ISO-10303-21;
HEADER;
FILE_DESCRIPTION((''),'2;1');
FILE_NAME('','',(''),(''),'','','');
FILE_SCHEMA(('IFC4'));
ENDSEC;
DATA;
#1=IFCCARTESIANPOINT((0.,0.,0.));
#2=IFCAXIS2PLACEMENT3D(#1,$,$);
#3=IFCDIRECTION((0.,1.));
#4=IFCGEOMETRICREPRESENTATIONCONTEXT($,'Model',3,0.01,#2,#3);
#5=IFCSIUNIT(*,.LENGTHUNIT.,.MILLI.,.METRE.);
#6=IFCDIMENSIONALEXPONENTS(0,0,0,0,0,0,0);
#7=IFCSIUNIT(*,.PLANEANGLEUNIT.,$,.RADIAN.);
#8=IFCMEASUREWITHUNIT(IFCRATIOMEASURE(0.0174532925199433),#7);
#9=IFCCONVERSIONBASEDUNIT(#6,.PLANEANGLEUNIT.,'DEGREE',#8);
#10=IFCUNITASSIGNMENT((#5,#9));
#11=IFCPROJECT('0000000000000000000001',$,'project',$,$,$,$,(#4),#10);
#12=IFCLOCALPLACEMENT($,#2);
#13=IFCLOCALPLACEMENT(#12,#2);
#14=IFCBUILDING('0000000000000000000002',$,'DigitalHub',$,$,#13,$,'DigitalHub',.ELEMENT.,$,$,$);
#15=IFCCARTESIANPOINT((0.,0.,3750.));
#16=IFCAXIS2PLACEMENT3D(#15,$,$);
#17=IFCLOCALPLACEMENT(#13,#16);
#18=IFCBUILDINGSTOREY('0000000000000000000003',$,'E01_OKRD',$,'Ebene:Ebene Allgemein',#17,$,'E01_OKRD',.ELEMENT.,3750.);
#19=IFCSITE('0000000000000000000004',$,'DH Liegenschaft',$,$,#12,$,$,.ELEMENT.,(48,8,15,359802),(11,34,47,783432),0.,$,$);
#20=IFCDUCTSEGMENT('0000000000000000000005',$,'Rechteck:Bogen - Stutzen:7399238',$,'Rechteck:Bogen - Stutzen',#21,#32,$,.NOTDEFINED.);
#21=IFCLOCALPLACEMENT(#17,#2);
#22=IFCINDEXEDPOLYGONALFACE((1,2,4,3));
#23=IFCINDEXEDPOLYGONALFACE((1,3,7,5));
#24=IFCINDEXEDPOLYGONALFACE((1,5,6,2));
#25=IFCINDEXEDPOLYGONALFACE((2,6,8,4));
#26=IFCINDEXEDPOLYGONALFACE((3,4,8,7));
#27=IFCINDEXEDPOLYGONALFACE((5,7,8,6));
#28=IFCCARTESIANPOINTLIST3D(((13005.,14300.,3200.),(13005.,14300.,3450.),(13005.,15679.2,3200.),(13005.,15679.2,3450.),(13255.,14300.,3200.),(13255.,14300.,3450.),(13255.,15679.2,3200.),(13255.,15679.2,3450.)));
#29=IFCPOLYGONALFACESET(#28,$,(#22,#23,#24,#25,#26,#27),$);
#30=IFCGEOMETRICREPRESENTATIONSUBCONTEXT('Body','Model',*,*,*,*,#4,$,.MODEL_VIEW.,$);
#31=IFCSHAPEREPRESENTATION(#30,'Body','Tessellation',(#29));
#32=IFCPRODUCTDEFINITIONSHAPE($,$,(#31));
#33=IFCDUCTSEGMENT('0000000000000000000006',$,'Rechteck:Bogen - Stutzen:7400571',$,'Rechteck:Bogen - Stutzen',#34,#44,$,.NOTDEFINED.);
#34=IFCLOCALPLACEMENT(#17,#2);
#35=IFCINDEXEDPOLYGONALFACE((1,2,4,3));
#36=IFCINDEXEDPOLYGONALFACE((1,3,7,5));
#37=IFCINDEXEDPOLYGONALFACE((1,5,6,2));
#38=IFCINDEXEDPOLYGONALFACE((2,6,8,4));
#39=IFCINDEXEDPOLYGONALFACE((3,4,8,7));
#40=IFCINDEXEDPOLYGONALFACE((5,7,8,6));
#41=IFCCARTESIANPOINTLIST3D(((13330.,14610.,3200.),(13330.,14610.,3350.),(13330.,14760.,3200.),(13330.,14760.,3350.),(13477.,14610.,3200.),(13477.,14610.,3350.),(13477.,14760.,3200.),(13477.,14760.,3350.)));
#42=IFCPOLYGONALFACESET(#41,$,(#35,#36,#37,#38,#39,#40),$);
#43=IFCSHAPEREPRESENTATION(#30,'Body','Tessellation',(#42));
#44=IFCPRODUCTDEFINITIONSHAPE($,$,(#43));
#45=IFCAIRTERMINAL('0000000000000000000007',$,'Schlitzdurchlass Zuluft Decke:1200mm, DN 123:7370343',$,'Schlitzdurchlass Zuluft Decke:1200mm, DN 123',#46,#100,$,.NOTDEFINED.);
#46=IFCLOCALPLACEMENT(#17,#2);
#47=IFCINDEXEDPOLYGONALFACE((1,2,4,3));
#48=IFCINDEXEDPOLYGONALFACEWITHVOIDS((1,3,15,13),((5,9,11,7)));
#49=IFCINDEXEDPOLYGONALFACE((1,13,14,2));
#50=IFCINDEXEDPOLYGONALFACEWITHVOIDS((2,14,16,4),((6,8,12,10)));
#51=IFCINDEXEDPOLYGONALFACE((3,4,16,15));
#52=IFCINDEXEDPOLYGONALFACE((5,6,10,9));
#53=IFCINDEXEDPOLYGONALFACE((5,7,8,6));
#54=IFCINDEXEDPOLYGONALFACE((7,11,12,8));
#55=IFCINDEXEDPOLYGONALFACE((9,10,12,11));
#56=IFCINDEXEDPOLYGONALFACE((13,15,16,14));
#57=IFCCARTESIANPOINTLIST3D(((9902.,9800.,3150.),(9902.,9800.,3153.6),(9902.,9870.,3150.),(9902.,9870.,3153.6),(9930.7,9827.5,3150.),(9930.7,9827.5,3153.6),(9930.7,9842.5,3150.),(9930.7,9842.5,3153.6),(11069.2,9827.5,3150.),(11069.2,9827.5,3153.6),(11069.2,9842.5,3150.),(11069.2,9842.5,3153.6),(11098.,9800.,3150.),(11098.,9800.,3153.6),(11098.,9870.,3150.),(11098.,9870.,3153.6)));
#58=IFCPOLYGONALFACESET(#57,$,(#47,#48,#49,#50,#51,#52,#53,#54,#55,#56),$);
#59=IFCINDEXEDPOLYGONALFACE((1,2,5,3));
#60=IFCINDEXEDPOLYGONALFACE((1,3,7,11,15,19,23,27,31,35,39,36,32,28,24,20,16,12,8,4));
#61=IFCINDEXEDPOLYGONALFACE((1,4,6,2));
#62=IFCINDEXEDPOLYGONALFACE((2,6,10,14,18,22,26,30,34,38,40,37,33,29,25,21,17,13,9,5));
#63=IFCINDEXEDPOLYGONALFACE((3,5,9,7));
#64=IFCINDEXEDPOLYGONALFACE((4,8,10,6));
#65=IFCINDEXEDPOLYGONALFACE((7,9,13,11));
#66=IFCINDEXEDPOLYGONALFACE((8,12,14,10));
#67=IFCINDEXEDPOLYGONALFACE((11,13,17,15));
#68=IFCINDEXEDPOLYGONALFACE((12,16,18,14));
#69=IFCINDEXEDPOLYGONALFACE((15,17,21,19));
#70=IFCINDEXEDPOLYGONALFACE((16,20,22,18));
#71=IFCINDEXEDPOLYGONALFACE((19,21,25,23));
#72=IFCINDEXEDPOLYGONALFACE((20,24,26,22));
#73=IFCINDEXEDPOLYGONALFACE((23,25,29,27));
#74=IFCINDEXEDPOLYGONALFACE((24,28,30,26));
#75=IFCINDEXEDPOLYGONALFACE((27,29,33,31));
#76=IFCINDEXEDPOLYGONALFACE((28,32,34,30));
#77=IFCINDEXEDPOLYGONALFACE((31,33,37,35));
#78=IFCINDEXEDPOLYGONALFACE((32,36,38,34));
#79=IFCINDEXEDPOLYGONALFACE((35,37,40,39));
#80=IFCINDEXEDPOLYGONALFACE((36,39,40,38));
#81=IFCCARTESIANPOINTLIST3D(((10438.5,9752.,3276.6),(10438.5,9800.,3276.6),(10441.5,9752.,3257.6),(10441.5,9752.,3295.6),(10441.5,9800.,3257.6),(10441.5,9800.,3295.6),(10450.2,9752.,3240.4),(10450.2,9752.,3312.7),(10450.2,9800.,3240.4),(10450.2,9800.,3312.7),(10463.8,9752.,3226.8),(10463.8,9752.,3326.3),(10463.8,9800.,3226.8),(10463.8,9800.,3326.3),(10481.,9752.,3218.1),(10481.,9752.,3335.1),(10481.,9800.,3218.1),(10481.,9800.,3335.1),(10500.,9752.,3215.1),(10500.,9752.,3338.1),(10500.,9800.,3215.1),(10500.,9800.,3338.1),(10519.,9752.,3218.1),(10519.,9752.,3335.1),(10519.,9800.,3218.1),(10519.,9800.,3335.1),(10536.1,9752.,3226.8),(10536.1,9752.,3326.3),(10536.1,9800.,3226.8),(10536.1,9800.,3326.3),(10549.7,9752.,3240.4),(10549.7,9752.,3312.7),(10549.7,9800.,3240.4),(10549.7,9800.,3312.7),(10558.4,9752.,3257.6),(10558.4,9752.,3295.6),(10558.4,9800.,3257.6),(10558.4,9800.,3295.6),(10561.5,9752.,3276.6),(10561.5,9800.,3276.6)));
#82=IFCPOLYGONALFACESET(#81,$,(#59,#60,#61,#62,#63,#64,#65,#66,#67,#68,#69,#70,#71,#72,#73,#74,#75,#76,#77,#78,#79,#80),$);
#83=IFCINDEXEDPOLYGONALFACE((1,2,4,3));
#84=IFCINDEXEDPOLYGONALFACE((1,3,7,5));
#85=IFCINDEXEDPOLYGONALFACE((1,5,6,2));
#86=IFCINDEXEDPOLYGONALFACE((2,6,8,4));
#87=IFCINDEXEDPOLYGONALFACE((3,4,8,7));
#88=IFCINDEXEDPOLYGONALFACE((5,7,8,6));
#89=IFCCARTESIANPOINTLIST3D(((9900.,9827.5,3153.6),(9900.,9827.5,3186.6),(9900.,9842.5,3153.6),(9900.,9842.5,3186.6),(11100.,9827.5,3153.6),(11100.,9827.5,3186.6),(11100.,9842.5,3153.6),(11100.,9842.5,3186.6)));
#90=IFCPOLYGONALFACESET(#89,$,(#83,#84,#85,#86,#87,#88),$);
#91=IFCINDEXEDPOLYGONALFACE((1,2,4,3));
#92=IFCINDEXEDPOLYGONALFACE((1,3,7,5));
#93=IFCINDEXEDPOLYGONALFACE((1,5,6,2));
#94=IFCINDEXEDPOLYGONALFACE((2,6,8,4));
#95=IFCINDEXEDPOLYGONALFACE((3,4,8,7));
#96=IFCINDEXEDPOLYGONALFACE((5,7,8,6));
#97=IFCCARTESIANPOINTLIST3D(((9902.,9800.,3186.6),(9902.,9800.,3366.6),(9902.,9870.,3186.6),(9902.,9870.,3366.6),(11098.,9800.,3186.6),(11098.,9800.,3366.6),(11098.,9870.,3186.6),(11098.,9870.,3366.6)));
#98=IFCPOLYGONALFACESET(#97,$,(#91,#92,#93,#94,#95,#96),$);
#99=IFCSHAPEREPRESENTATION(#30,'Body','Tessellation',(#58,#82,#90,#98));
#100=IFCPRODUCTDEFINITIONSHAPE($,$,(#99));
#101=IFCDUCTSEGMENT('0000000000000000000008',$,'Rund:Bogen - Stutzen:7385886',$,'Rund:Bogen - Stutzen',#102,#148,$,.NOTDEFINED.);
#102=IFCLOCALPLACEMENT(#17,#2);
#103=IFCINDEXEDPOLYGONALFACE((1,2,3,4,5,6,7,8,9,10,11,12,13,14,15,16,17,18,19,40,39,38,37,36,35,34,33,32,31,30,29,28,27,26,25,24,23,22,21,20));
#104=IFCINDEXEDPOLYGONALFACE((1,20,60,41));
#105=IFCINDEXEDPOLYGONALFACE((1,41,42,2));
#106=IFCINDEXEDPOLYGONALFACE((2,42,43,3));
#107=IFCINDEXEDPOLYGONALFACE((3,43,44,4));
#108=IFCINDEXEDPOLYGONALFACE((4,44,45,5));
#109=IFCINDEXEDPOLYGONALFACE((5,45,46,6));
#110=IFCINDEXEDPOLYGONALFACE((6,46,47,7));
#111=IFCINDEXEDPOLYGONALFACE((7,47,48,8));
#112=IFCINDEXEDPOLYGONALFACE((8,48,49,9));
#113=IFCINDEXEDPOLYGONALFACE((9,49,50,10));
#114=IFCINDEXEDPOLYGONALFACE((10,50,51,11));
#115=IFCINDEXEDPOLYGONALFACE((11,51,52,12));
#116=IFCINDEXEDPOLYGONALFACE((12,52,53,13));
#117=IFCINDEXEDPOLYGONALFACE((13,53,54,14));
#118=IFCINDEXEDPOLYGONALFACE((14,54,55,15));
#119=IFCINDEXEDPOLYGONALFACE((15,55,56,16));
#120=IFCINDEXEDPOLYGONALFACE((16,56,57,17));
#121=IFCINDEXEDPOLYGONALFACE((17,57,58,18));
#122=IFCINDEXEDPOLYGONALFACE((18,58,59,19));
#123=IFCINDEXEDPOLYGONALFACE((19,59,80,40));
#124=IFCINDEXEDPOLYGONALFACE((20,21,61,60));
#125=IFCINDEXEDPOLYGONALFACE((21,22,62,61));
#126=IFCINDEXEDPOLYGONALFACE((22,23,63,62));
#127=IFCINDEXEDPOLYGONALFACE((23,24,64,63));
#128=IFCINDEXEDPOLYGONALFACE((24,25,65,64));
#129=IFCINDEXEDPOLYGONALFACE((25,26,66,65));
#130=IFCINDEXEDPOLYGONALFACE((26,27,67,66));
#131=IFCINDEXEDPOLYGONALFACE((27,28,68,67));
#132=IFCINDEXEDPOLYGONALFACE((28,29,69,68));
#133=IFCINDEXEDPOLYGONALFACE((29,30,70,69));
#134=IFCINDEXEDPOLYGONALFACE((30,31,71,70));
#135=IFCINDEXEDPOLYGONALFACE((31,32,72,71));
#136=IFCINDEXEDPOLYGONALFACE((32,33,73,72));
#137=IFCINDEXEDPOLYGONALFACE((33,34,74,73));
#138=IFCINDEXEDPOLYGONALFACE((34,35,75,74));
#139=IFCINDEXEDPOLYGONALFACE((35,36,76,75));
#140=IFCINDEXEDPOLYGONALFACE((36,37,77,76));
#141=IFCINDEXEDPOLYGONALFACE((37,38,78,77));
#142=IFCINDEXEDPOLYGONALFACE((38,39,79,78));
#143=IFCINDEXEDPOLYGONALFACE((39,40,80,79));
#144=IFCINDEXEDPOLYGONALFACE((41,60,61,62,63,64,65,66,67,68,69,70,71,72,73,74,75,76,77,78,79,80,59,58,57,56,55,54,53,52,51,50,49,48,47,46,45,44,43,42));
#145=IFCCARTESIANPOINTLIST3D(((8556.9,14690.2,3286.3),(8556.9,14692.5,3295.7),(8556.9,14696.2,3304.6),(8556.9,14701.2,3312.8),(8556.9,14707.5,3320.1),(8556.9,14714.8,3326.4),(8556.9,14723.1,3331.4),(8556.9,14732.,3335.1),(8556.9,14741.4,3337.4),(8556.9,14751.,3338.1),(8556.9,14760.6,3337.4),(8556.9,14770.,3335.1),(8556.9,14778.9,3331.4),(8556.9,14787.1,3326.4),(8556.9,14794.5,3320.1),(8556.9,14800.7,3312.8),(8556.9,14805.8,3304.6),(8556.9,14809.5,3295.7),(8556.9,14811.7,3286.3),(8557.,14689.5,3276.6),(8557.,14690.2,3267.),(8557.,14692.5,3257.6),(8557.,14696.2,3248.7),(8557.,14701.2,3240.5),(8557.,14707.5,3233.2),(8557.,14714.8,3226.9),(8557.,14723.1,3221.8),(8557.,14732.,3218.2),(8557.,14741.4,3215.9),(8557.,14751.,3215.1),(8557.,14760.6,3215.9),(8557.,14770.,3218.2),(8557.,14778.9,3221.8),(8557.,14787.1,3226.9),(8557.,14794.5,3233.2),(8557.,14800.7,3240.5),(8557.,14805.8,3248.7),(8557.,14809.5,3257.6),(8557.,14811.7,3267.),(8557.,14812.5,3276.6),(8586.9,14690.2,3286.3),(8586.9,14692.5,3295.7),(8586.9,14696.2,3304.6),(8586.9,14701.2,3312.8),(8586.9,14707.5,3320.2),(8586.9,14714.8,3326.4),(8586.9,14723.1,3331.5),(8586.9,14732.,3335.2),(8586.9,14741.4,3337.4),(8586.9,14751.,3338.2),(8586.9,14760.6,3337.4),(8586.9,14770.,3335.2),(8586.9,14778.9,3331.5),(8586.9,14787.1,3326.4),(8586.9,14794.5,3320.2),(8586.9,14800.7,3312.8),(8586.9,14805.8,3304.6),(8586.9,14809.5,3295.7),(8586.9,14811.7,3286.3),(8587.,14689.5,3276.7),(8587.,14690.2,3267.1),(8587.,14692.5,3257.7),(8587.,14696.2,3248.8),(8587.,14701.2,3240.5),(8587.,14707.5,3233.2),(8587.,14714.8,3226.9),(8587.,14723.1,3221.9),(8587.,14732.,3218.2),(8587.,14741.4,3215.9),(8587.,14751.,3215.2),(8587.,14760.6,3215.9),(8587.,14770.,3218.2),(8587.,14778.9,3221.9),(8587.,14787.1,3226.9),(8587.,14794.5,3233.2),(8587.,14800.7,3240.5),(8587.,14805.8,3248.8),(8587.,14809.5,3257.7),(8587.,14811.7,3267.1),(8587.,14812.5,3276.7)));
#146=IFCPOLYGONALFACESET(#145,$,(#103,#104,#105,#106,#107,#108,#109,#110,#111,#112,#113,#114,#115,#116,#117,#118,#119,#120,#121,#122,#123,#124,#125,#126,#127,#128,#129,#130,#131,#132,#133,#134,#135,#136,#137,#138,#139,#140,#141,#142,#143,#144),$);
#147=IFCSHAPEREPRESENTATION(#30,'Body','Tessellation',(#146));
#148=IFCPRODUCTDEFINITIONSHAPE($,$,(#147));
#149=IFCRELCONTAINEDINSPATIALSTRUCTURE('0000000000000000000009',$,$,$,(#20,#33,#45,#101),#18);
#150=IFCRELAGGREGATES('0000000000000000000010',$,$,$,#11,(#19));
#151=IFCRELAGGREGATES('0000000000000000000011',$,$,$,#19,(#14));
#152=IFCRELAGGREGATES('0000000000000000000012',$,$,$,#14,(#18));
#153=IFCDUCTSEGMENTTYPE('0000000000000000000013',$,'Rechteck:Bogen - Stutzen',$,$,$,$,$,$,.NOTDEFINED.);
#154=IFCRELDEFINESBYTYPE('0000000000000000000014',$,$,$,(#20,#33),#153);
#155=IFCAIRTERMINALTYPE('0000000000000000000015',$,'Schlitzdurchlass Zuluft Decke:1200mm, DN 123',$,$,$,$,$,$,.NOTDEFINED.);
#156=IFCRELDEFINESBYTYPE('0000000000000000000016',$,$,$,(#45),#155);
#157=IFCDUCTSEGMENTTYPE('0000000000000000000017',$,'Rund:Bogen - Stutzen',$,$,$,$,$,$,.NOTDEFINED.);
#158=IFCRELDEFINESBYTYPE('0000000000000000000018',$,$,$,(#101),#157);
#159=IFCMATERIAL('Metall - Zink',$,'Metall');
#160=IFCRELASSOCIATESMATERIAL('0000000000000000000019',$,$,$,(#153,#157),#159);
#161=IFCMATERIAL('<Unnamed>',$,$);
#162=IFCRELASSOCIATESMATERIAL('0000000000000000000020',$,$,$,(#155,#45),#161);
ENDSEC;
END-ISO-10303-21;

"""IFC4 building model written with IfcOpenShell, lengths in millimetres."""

from ifc_helpers import new_model, entity, si_unit, converted_unit, direction, frame, origin, place, context, subcontext, project, spatial, indexed_curve, outline, extrude, source, transform, mapped, material, type_object, type_shapes, element, save


model = new_model("IFC4")

# Units and contexts
model_context = context("Model", 3, precision=0.01, world=origin(), true_north=direction((0.0, 1.0)))
body_context = subcontext(model_context, "Body", "Model", "MODEL_VIEW")
ifc_project = project(units=[si_unit("LENGTHUNIT", "METRE", prefix="MILLI"), converted_unit("PLANEANGLEUNIT", "DEGREE", entity("IfcRatioMeasure", 0.0174532925199433), si_unit("PLANEANGLEUNIT", "RADIAN"), dimensions=[0, 0, 0, 0, 0, 0, 0])], contexts=[model_context])

# Site, building, storey
site_placement = place(None, origin())
site = spatial("IfcSite", under=ifc_project, at=site_placement, Name="DH Liegenschaft", CompositionType="ELEMENT", RefLatitude=(48, 8, 15, 359802), RefLongitude=(11, 34, 47, 783432), RefElevation=0.0)
building_placement = place(site_placement, origin())
building = spatial("IfcBuilding", under=site, at=building_placement, Name="DigitalHub", LongName="DigitalHub", CompositionType="ELEMENT")
storey_placement = place(building_placement, frame((0.0, 0.0, 3750.0)))
storey = spatial("IfcBuildingStorey", under=building, at=storey_placement, Name="E01_OKRD", ObjectType="Ebene:Ebene Allgemein", LongName="E01_OKRD", CompositionType="ELEMENT", Elevation=3750.0)

# Duct segments
ifc_material_1 = material(Name="Metall - Zink", Category="Metall")
duct_segment_type_1 = type_object("IfcDuctSegmentType", Name="Rechteck:Bogen - Stutzen", PredefinedType="NOTDEFINED", material=ifc_material_1)
duct_segment_1_placement = place(storey_placement, frame((13005.0, 14300.0, 3200.0)))
element("IfcDuctSegment", 1, at=duct_segment_1_placement, inside=storey, type_object=duct_segment_type_1, Name="Rechteck:Bogen - Stutzen:7399238", ObjectType="Rechteck:Bogen - Stutzen", PredefinedType="NOTDEFINED", context=body_context, shape_type="SweptSolid", body=[
    extrude(outline(indexed_curve([(-689.6, -125.0), (689.6, -125.0), (689.6, 125.0), (-689.6, 125.0), (-689.6, -125.0)], self_intersect=False)), frame((125.0, 689.6, 0.0), z_axis=(0.0, 0.0, 1.0), x_axis=(0.0, 1.0, 0.0)), (0.0, 0.0, 1.0), 250.0),
])
duct_segment_2_placement = place(storey_placement, frame((13330.0, 14610.0, 3200.0)))
element("IfcDuctSegment", 2, at=duct_segment_2_placement, inside=storey, type_object=duct_segment_type_1, Name="Rechteck:Bogen - Stutzen:7400571", ObjectType="Rechteck:Bogen - Stutzen", PredefinedType="NOTDEFINED", context=body_context, shape_type="SweptSolid", body=[
    extrude(outline(indexed_curve([(-73.5, -75.0), (73.5, -75.0), (73.5, 75.0), (-73.5, 75.0), (-73.5, -75.0)], self_intersect=False)), frame((73.5, 75.0, 0.0), z_axis=(0.0, 0.0, 1.0), x_axis=(-1.0, 0.0, 0.0)), (0.0, 0.0, 1.0), 150.0),
])

# Air terminal
ifc_material_2 = material(Name="<Unnamed>")
air_terminal_type_1 = type_object("IfcAirTerminalType", Name="Schlitzdurchlass Zuluft Decke:1200mm, DN 123", PredefinedType="NOTDEFINED", material=ifc_material_2)
shared_shape_1 = source(origin(), body_context, "Body", "SweptSolid", [
    extrude(outline(indexed_curve([(-598.0, -35.0), (598.0, -35.0), (598.0, 35.0), (-598.0, 35.0), (-598.0, -35.0)], self_intersect=False), holes=[indexed_curve([(-569.2, -7.5), (-569.2, 7.5), (569.2, 7.5), (569.2, -7.5), (-569.2, -7.5)], self_intersect=False)]), frame((600.0, 35.0, 0.0), z_axis=(0.0, 0.0, 1.0), x_axis=(-1.0, 0.0, 0.0)), (0.0, 0.0, 1.0), 3.6),
    extrude(outline(indexed_curve([(61.5, 0.0), (58.5, 19.0), (49.8, 36.1), (36.1, 49.8), (19.0, 58.5), (0.0, 61.5), (-19.0, 58.5), (-36.1, 49.8), (-49.8, 36.1), (-58.5, 19.0), (-61.5, 0.0), (-58.5, -19.0), (-49.8, -36.1), (-36.1, -49.8), (-19.0, -58.5), (0.0, -61.5), (19.0, -58.5), (36.1, -49.8), (49.8, -36.1), (58.5, -19.0), (61.5, 0.0)], self_intersect=False)), frame((600.0, 70.0, 126.6), z_axis=(0.0, 1.0, 0.0), x_axis=(-1.0, 0.0, 0.0)), (0.0, 0.0, 1.0), 48.0),
    extrude(outline(indexed_curve([(-600.0, -7.5), (600.0, -7.5), (600.0, 7.5), (-600.0, 7.5), (-600.0, -7.5)], self_intersect=False)), frame((600.0, 35.0, 3.6), z_axis=(0.0, 0.0, 1.0), x_axis=(-1.0, 0.0, 0.0)), (0.0, 0.0, 1.0), 33.0),
    extrude(outline(indexed_curve([(-598.0, -35.0), (598.0, -35.0), (598.0, 35.0), (-598.0, 35.0), (-598.0, -35.0)], self_intersect=False)), frame((600.0, 35.0, 36.6), z_axis=(0.0, 0.0, 1.0), x_axis=(-1.0, 0.0, 0.0)), (0.0, 0.0, 1.0), 180.0),
])
type_shapes(air_terminal_type_1, [shared_shape_1])
air_terminal_1_placement = place(storey_placement, frame((11100.0, 9870.0, 3150.0), z_axis=(0.0, 0.0, 1.0), x_axis=(-1.0, 0.0, 0.0)))
element("IfcAirTerminal", 3, at=air_terminal_1_placement, inside=storey, type_object=air_terminal_type_1, material=ifc_material_2, Name="Schlitzdurchlass Zuluft Decke:1200mm, DN 123:7370343", ObjectType="Schlitzdurchlass Zuluft Decke:1200mm, DN 123", PredefinedType="NOTDEFINED", context=body_context, shape_type="MappedRepresentation", body=[
    mapped(shared_shape_1, transform((0.0, 0.0, 0.0), scale=1.0)),
])

# Duct segment
duct_segment_type_2 = type_object("IfcDuctSegmentType", Name="Rund:Bogen - Stutzen", PredefinedType="NOTDEFINED", material=ifc_material_1)
duct_segment_3_placement = place(storey_placement, frame((8556.9, 14687.9, 3213.6)))
element("IfcDuctSegment", 4, at=duct_segment_3_placement, inside=storey, type_object=duct_segment_type_2, Name="Rund:Bogen - Stutzen:7385886", ObjectType="Rund:Bogen - Stutzen", PredefinedType="NOTDEFINED", context=body_context, shape_type="SweptSolid", body=[
    extrude(outline(indexed_curve([(61.5, 0.0), (60.7, 9.6), (58.5, 19.0), (54.8, 27.9), (49.8, 36.1), (43.5, 43.5), (36.1, 49.8), (27.9, 54.8), (19.0, 58.5), (9.6, 60.7), (0.0, 61.5), (-9.6, 60.7), (-19.0, 58.5), (-27.9, 54.8), (-36.1, 49.8), (-43.5, 43.5), (-49.8, 36.1), (-54.8, 27.9), (-58.5, 19.0), (-60.7, 9.6), (-61.5, 0.0), (-60.7, -9.6), (-58.5, -19.0), (-54.8, -27.9), (-49.8, -36.1), (-43.5, -43.5), (-36.1, -49.8), (-27.9, -54.8), (-19.0, -58.5), (-9.6, -60.7), (0.0, -61.5), (9.6, -60.7), (19.0, -58.5), (27.9, -54.8), (36.1, -49.8), (43.5, -43.5), (49.8, -36.1), (54.8, -27.9), (58.5, -19.0), (60.7, -9.6), (61.5, 0.0)], self_intersect=False)), frame((0.1, 63.1, 63.1), z_axis=(1.0, 0.0, 0.000858), x_axis=(0.0, -1.0, 0.0)), (0.0, 0.0, 1.0), 30.0),
])

save(model, "model.ifc")
